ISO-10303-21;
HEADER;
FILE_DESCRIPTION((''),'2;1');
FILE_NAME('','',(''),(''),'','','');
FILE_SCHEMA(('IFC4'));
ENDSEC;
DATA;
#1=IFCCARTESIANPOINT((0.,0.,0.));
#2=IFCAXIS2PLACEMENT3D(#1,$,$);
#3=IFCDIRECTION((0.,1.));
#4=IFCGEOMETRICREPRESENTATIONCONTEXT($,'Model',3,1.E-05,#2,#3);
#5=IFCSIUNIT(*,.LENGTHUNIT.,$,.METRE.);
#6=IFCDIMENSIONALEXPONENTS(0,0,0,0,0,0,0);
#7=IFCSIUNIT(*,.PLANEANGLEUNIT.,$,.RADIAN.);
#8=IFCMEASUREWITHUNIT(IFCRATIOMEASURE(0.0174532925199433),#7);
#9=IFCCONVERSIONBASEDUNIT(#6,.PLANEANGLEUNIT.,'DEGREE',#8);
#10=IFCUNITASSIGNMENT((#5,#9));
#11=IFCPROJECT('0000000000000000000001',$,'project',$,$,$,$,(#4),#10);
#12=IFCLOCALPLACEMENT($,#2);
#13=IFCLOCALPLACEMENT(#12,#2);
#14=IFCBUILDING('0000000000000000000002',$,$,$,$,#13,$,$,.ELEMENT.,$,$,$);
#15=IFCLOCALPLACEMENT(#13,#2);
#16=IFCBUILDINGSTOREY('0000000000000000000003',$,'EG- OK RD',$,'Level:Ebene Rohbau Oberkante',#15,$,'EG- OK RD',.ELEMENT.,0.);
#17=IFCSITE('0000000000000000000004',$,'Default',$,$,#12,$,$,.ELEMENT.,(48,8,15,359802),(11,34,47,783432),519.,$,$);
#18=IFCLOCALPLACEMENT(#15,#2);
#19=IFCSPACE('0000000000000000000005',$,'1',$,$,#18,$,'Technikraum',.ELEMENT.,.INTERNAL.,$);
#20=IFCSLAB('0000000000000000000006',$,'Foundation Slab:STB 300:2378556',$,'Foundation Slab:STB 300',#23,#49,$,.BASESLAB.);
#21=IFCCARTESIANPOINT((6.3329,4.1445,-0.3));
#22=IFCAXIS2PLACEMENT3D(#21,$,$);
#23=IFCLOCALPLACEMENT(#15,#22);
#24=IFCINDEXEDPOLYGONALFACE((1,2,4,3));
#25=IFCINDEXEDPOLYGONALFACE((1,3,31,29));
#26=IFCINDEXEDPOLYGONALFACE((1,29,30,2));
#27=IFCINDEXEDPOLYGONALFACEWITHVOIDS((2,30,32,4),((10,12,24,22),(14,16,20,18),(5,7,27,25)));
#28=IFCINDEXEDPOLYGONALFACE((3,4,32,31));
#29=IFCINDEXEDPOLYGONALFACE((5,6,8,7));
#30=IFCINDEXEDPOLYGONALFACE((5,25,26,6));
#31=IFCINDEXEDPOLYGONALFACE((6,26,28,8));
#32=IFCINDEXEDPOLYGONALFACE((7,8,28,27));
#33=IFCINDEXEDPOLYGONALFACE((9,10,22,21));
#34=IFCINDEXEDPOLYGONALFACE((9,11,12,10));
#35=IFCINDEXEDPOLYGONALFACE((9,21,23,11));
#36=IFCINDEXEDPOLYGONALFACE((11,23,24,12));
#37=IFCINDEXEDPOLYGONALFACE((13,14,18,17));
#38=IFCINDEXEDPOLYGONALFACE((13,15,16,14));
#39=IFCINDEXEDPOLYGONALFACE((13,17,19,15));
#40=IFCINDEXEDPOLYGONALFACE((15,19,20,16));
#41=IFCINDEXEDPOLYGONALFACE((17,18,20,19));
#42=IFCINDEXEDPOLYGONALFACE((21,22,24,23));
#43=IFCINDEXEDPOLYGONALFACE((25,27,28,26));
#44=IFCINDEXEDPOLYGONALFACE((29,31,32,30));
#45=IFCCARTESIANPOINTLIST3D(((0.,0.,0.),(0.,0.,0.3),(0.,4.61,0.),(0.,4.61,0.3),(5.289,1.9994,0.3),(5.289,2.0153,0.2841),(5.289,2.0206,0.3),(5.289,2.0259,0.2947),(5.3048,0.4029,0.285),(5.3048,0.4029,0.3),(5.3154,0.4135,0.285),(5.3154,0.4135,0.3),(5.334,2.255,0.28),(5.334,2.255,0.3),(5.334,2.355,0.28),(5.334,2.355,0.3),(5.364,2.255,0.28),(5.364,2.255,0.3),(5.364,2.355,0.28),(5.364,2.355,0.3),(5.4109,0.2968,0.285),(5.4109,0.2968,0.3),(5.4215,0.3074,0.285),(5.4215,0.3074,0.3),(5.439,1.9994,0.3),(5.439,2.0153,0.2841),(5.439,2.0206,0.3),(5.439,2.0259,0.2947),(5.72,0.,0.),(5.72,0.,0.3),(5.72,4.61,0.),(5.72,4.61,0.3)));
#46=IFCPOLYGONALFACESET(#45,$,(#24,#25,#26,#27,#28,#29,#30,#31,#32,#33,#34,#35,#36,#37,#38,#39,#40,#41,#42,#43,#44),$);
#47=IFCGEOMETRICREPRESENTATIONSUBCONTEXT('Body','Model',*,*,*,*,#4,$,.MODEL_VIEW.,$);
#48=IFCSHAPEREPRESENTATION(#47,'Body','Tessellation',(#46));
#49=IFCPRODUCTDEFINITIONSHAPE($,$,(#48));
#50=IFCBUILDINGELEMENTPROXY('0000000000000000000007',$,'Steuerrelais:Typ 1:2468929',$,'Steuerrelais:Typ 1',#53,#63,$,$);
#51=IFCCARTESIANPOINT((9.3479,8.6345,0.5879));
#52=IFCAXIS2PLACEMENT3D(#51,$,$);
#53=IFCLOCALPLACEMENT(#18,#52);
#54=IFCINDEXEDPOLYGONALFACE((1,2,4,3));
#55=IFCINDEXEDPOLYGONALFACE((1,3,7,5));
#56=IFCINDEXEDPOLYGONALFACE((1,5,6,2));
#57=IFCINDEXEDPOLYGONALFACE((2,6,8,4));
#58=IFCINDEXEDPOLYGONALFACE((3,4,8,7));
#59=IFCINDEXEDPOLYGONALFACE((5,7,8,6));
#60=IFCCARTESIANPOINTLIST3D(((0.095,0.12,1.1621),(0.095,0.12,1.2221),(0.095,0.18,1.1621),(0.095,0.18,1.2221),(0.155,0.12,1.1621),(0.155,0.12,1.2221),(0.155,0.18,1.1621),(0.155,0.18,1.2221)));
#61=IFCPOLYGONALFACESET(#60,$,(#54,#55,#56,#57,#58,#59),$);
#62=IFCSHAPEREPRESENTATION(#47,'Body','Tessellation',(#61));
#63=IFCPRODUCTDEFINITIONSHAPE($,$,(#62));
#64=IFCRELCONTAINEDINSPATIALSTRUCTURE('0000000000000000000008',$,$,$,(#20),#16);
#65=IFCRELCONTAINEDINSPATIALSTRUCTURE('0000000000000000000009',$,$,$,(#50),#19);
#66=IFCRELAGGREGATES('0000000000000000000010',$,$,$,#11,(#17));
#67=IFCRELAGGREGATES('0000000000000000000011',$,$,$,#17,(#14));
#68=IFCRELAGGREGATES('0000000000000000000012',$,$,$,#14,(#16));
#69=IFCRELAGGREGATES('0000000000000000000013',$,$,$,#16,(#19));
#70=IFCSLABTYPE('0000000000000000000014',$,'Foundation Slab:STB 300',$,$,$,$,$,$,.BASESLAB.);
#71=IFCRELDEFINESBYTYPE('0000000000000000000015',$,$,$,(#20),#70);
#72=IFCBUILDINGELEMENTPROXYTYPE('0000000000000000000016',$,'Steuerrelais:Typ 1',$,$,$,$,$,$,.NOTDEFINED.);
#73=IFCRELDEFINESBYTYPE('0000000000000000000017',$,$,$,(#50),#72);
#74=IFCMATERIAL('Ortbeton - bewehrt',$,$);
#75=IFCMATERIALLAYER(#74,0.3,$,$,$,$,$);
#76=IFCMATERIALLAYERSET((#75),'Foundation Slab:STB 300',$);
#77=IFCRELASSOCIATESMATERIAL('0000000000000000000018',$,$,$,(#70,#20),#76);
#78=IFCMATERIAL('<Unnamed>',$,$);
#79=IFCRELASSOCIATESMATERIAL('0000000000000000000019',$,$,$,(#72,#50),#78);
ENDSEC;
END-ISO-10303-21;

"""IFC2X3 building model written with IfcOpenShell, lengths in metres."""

from ifc_helpers import new_model, entity, si_unit, converted_unit, direction, frame, frame_2d, origin, origin_2d_with_axis, place, context, subcontext, project, spatial, rectangle, extrude, source, transform, mapped, material, layer, layer_set, layer_usage, type_object, type_shapes, element, save


model = new_model("IFC2X3")

# Units and contexts
model_context = context("Model", 3, precision=1e-05, world=origin(), true_north=direction((0.0, 1.0)))
body_context = subcontext(model_context, "Body", "Model", "MODEL_VIEW")
ifc_project = project(units=[si_unit("LENGTHUNIT", "METRE"), converted_unit("PLANEANGLEUNIT", "DEGREE", entity("IfcRatioMeasure", 0.0174532925199433), si_unit("PLANEANGLEUNIT", "RADIAN"), dimensions=[0, 0, 0, 0, 0, 0, 0])], contexts=[model_context])

# Site, building, storey
site_placement = place(None, origin())
site = spatial("IfcSite", under=ifc_project, at=site_placement, Name="Default", CompositionType="ELEMENT", RefLatitude=(48, 8, 15, 359802), RefLongitude=(11, 34, 47, 783432), RefElevation=519.0)
building_placement = place(site_placement, origin())
building = spatial("IfcBuilding", under=site, at=building_placement, CompositionType="ELEMENT")
storey_placement = place(building_placement, origin())
storey = spatial("IfcBuildingStorey", under=building, at=storey_placement, Name="EG- OK RD", ObjectType="Level:Ebene Rohbau Oberkante", LongName="EG- OK RD", CompositionType="ELEMENT", Elevation=0.0)

# Slab, openings
ifc_material_1 = material(Name="Ortbeton - bewehrt")
ifc_layer_1 = layer(ifc_material_1, 0.3)
ifc_layer_set_1 = layer_set([ifc_layer_1], Name="Foundation Slab:STB 300")
ifc_layer_usage_1 = layer_usage(ifc_layer_set_1, "AXIS3", "POSITIVE", 0.0)
slab_type_1 = type_object("IfcSlabType", Name="Foundation Slab:STB 300", PredefinedType="BASESLAB", material=ifc_layer_set_1)
slab_1_placement = place(storey_placement, frame((6.3329, 4.1445, -0.3)))
slab_1 = element("IfcSlab", 1, at=slab_1_placement, inside=storey, type_object=slab_type_1, material=ifc_layer_usage_1, Name="Foundation Slab:STB 300:2378556", ObjectType="Foundation Slab:STB 300", PredefinedType="BASESLAB", context=body_context, shape_type="SweptSolid", body=[
    extrude(rectangle(XDim=4.61, YDim=5.72, at=frame_2d((0.0, 0.0), x_axis=(0.0, -1.0))), frame((2.86, 2.305, 0.3), z_axis=(0.0, 0.0, -1.0), x_axis=(-1.0, 0.0, 0.0)), (0.0, 0.0, 1.0), 0.3),
])
opening_1_placement = place(slab_1_placement, origin())
element("IfcOpeningElement", 2, at=opening_1_placement, cuts=slab_1, ObjectType="Opening", context=body_context, shape_type="SweptSolid", body=[
    extrude(rectangle(XDim=0.03, YDim=0.1, at=origin_2d_with_axis()), frame((5.349, 2.305, 0.28), z_axis=(0.0, 0.0, 1.0), x_axis=(-1.0, 0.0, 0.0)), (0.0, 0.0, 1.0), 0.52),
])
opening_2_placement = place(slab_1_placement, origin())
element("IfcOpeningElement", 3, at=opening_2_placement, cuts=slab_1, ObjectType="Opening", context=body_context, shape_type="SweptSolid", body=[
    extrude(rectangle(XDim=0.0285, YDim=0.015, at=origin_2d_with_axis()), frame((5.289, 2.0105, 0.2995), z_axis=(1.0, 0.0, 0.0), x_axis=(0.0, 0.707107, -0.707107)), (0.0, 0.0, 1.0), 0.15),
])
opening_3_placement = place(slab_1_placement, origin())
element("IfcOpeningElement", 4, at=opening_3_placement, cuts=slab_1, ObjectType="Opening", context=body_context, shape_type="SweptSolid", body=[
    extrude(rectangle(XDim=0.015, YDim=0.15, at=origin_2d_with_axis()), frame((5.3632, 0.3552, 0.285), z_axis=(0.0, 0.0, 1.0), x_axis=(0.707107, 0.707107, 0.0)), (0.0, 0.0, 1.0), 0.0285),
])

# Shared definitions
space_placement = place(storey_placement, origin())
space = spatial("IfcSpace", under=storey, at=space_placement, Name="1", LongName="Technikraum", CompositionType="ELEMENT", InteriorOrExteriorSpace="INTERNAL")

# Building element proxy
ifc_material_2 = material(Name="<Unnamed>")
building_element_proxy_type = type_object("IfcBuildingElementProxyType", Name="Steuerrelais:Typ 1", PredefinedType="NOTDEFINED", material=ifc_material_2)
shared_shape = source(origin(), body_context, "Body", "SweptSolid", [
    extrude(rectangle(XDim=0.06, YDim=0.06, at=origin_2d_with_axis()), frame((0.125, 0.15, 1.1621), z_axis=(0.0, 0.0, 1.0), x_axis=(0.0, 1.0, 0.0)), (0.0, 0.0, 1.0), 0.06),
])
type_shapes(building_element_proxy_type, [shared_shape])
proxy_placement = place(space_placement, frame((9.3479, 8.6345, 0.5879)))
element("IfcBuildingElementProxy", 5, at=proxy_placement, inside=space, type_object=building_element_proxy_type, material=ifc_material_2, Name="Steuerrelais:Typ 1:2468929", ObjectType="Steuerrelais:Typ 1", context=body_context, shape_type="MappedRepresentation", body=[
    mapped(shared_shape, transform((0.0, 0.0, 0.0), scale=1.0)),
])

save(model, "model.ifc")
